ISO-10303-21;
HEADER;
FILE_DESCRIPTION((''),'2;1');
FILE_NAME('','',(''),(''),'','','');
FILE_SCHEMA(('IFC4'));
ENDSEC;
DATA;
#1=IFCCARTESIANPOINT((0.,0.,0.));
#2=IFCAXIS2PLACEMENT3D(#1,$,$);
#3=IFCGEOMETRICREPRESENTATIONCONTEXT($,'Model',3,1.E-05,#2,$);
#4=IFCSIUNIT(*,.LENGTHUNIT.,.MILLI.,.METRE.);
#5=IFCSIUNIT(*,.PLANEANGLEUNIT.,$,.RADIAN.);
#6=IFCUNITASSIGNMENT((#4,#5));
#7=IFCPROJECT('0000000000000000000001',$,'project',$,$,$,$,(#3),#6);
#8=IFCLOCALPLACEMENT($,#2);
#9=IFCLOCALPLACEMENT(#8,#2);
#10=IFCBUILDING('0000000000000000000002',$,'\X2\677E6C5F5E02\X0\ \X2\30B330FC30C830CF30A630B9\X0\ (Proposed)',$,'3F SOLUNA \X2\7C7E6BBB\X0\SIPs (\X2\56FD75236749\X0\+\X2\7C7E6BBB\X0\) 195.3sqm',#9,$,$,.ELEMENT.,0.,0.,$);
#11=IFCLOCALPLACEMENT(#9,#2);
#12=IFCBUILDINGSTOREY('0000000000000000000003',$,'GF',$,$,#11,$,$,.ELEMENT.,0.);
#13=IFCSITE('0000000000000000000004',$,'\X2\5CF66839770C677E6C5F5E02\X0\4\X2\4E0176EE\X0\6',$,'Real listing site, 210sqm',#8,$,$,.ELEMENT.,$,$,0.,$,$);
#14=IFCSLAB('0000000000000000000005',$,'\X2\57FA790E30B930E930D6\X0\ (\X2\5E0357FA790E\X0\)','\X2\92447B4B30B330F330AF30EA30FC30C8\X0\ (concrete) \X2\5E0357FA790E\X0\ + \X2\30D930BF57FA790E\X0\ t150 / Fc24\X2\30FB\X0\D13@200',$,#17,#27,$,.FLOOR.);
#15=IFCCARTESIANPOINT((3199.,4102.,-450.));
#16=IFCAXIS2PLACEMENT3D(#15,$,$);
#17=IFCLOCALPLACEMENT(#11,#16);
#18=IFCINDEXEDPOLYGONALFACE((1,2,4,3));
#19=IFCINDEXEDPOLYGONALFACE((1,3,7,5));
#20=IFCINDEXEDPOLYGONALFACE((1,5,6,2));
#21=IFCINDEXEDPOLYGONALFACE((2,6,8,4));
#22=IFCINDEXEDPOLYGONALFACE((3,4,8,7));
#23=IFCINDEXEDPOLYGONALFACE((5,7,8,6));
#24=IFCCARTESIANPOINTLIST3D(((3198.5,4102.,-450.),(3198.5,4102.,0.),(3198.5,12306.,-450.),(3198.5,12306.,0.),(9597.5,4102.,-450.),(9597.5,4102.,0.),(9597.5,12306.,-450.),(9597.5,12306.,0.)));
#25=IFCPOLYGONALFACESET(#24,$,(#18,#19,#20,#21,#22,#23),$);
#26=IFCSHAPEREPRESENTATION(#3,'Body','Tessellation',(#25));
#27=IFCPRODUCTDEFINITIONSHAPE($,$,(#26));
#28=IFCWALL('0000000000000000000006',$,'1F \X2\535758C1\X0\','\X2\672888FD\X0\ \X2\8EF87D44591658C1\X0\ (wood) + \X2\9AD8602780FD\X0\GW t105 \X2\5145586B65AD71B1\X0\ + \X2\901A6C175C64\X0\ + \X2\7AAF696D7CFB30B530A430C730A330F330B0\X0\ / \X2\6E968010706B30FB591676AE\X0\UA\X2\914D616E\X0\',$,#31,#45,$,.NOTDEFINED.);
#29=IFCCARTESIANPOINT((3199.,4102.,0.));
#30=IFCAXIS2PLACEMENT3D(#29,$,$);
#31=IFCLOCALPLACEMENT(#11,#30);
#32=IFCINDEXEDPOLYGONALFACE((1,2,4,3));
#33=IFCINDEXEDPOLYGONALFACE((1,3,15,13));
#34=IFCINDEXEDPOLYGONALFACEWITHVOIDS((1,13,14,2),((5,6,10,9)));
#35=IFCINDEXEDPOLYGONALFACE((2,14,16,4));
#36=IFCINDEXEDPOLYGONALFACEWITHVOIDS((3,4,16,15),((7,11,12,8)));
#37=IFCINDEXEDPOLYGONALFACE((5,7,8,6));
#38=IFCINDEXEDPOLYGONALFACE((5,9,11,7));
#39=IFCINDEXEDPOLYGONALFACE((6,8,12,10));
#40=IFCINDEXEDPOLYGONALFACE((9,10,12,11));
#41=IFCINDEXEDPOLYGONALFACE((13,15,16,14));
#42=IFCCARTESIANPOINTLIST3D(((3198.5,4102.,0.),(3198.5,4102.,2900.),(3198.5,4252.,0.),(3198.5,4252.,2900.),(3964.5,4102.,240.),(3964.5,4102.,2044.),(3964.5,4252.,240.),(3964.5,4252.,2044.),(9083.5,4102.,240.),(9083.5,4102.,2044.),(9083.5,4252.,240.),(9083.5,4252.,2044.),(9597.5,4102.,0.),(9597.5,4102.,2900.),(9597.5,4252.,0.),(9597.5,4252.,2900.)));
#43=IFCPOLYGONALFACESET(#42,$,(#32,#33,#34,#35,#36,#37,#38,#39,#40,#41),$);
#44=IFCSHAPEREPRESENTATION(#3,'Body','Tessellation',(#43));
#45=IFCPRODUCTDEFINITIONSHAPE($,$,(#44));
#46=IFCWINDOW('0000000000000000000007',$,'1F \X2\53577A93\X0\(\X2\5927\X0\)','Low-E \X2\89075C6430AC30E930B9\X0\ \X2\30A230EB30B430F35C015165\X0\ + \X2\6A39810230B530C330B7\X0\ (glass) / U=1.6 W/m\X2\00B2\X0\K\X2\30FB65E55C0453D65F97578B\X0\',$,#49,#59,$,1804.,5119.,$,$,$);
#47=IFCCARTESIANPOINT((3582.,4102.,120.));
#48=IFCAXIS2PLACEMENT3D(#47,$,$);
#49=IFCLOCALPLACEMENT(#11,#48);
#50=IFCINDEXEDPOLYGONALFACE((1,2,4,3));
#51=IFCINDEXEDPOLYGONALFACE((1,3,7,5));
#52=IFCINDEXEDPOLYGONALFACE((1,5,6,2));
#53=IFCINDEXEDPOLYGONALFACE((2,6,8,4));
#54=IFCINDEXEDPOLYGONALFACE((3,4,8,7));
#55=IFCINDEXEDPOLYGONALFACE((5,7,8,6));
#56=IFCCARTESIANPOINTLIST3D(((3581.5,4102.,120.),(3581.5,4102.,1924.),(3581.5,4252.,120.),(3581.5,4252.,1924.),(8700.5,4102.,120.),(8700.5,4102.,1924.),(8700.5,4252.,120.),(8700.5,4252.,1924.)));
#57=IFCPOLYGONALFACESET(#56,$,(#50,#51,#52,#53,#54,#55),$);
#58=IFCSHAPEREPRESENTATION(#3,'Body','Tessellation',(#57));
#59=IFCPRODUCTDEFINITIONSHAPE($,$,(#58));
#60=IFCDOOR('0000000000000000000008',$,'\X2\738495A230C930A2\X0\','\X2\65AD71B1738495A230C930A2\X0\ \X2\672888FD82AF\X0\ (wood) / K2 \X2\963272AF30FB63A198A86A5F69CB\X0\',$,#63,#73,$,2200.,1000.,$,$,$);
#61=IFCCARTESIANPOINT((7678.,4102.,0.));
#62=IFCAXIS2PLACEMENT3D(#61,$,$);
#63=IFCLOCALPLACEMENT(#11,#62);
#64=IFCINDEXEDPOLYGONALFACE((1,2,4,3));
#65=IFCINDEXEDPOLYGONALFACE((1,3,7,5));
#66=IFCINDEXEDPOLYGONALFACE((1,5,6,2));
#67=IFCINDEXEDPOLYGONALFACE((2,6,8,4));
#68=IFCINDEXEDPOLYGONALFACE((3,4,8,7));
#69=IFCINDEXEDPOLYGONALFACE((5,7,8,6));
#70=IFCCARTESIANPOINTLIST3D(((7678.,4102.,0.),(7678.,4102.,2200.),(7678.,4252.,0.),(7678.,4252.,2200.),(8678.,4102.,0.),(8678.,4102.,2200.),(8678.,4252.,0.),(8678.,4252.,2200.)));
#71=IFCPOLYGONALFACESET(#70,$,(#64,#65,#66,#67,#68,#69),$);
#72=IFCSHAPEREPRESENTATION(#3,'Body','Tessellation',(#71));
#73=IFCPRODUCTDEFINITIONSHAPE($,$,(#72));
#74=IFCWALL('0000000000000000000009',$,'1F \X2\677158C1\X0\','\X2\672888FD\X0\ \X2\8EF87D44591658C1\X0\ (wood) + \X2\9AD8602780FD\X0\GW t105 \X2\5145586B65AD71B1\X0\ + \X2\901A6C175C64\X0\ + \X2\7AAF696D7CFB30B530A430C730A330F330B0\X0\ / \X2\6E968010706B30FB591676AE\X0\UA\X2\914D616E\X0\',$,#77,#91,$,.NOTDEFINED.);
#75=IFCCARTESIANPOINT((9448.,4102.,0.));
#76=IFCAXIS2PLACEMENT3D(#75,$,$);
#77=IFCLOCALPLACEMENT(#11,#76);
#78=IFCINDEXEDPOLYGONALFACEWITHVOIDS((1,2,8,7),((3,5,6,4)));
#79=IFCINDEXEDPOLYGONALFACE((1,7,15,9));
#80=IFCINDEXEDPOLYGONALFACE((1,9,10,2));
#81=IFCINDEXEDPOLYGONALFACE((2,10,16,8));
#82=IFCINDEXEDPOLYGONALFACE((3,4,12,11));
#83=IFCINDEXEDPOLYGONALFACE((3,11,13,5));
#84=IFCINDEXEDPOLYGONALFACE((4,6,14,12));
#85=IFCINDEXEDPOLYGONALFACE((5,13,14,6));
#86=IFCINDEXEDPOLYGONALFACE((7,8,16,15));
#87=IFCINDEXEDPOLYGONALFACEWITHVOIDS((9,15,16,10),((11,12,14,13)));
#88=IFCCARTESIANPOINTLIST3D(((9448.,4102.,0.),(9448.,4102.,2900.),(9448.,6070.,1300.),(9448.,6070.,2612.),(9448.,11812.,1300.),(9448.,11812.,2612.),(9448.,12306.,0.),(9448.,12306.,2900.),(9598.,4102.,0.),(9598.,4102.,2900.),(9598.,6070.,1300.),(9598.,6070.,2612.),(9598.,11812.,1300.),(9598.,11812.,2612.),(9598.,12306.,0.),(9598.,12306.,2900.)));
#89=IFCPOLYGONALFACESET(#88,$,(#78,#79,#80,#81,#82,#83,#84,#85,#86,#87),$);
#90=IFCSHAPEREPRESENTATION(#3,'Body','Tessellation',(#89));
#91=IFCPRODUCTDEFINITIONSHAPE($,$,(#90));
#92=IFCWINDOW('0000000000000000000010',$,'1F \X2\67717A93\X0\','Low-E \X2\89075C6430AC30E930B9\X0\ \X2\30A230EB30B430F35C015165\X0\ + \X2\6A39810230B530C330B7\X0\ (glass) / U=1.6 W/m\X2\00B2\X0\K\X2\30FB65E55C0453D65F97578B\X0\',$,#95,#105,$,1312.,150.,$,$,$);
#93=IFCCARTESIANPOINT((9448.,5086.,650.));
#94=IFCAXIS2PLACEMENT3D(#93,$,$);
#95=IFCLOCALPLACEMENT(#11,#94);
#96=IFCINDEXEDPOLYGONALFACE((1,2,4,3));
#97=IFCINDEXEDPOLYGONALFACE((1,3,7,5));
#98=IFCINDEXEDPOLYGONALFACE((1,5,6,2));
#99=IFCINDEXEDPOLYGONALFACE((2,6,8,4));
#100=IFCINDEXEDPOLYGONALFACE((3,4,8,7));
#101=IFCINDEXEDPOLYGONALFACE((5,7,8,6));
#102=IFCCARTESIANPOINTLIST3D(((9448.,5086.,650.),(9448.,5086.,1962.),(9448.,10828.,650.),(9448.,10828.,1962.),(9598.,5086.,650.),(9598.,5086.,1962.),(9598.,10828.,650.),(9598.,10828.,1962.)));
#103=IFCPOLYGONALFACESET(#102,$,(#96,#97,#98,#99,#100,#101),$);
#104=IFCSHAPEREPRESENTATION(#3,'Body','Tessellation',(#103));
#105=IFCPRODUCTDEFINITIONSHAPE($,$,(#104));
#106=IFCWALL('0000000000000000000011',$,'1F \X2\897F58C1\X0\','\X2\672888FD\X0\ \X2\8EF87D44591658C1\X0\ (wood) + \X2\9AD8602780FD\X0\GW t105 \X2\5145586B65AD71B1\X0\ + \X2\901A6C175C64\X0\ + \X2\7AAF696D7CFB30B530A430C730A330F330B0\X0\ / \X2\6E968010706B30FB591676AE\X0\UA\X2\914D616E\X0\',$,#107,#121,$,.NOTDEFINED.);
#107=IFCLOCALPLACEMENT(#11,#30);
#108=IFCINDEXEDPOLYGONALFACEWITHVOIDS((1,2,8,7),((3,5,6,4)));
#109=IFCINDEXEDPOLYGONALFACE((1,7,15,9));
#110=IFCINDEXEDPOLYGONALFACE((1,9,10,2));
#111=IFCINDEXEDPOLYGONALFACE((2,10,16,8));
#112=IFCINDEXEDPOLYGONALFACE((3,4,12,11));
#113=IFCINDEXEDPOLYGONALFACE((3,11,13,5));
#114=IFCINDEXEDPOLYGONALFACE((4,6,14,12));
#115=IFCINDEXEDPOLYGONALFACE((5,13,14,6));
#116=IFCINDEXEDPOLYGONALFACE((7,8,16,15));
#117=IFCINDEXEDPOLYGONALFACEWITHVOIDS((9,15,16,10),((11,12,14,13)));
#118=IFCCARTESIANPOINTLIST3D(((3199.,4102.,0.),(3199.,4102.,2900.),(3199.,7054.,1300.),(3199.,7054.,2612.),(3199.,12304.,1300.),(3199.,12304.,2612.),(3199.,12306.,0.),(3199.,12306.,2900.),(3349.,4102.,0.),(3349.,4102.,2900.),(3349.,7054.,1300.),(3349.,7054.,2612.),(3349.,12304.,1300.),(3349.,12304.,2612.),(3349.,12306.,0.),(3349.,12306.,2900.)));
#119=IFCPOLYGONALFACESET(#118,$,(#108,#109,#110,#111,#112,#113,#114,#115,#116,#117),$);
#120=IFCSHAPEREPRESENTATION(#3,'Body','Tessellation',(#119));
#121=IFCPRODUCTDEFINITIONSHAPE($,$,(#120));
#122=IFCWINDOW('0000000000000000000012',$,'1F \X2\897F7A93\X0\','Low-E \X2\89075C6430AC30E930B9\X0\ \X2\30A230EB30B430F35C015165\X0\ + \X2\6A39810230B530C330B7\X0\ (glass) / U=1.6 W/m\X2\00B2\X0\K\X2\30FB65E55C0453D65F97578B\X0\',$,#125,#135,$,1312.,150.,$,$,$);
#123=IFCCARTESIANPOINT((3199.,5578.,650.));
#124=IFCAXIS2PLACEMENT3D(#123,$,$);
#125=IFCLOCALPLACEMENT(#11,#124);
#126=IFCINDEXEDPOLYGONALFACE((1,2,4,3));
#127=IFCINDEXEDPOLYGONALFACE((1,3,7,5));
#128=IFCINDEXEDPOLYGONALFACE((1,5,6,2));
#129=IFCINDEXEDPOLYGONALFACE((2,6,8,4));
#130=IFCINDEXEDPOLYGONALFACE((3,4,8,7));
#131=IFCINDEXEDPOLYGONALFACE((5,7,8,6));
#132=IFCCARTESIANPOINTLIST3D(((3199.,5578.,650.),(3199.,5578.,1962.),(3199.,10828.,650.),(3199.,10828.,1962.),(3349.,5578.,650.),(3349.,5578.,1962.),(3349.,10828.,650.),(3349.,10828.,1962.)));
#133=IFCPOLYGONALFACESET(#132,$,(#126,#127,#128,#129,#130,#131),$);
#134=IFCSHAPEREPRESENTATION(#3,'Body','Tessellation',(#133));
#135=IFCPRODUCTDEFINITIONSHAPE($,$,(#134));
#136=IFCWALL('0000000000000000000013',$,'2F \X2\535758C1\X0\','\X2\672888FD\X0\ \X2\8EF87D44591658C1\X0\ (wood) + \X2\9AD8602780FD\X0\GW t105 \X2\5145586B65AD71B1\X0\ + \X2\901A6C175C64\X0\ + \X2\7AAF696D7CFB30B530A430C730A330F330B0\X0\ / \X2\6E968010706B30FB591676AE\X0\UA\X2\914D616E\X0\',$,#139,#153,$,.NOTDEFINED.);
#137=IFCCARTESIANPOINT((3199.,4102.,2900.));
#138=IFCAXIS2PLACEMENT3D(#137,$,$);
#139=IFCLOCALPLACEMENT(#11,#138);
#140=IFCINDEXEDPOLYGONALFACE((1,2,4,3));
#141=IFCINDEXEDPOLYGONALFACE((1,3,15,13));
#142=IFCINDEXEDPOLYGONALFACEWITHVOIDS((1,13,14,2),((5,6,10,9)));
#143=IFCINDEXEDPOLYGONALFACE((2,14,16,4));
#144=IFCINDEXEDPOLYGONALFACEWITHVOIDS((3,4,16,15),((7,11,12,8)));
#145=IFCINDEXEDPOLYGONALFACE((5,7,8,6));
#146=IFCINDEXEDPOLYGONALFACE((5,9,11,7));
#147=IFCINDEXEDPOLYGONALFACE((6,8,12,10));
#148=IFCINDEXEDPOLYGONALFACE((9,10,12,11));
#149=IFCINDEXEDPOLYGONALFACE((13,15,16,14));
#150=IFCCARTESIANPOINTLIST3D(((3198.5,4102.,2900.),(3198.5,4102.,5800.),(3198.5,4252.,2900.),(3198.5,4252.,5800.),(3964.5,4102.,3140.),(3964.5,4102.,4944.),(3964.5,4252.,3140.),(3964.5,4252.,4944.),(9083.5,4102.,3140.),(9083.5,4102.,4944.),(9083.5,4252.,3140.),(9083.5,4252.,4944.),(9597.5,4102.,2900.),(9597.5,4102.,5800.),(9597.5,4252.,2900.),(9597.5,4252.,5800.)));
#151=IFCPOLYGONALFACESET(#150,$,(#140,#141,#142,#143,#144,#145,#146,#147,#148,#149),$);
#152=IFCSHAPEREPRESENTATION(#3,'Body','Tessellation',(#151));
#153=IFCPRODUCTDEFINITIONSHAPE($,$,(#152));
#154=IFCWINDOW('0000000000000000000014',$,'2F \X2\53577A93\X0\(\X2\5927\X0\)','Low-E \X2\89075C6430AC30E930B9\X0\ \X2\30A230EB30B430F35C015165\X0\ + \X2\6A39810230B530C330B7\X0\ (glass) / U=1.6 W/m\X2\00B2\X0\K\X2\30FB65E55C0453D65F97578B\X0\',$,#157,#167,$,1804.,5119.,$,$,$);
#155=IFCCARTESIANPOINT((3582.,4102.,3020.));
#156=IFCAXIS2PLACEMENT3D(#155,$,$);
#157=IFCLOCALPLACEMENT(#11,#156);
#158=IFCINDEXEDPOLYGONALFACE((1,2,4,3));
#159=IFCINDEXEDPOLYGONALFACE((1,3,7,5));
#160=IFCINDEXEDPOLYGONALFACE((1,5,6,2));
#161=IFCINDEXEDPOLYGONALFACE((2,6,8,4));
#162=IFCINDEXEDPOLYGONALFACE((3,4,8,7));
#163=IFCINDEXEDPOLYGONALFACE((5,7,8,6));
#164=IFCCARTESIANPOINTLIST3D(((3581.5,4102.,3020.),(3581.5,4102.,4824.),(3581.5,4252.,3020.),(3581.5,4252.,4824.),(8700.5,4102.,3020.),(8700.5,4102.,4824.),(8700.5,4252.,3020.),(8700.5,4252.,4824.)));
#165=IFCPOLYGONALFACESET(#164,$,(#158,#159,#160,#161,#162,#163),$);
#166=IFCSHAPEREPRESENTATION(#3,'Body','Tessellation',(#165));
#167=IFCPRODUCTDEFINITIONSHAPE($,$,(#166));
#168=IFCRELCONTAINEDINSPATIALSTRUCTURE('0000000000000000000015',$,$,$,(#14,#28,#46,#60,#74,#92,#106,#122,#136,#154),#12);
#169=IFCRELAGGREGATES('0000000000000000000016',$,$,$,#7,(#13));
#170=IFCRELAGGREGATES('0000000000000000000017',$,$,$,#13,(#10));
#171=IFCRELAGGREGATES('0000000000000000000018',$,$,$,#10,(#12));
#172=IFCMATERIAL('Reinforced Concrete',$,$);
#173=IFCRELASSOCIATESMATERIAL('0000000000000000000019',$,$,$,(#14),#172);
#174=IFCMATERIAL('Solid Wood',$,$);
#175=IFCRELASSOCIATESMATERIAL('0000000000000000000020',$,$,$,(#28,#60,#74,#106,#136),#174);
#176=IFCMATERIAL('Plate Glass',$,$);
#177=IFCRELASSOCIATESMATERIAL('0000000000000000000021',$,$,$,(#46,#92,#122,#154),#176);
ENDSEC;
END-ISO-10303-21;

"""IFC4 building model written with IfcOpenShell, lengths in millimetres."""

from ifc_helpers import new_model, si_unit, frame, frame_2d, origin, place, context, project, spatial, rectangle, extrude, material, element, fill, save


model = new_model("IFC4")

# Units and contexts
model_context = context("Model", 3, precision=1e-05, world=origin())
ifc_project = project(units=[si_unit("LENGTHUNIT", "METRE", prefix="MILLI"), si_unit("PLANEANGLEUNIT", "RADIAN")], contexts=[model_context])

# Site, building, storey
site_placement = place(None, origin())
site = spatial("IfcSite", under=ifc_project, at=site_placement, Name="島根県松江市4丁目6", ObjectType="Real listing site, 210sqm", CompositionType="ELEMENT", RefElevation=0.0)
building_placement = place(site_placement, origin())
building = spatial("IfcBuilding", under=site, at=building_placement, Name="松江市 コートハウス (Proposed)", ObjectType="3F SOLUNA 籾殻SIPs (国産杉+籾殻) 195.3sqm", CompositionType="ELEMENT", ElevationOfRefHeight=0.0, ElevationOfTerrain=0.0)
storey_placement = place(building_placement, origin())
storey = spatial("IfcBuildingStorey", under=building, at=storey_placement, Name="GF", CompositionType="ELEMENT", Elevation=0.0)

# Slab
ifc_material_1 = material(Name="Reinforced Concrete")
slab_1_placement = place(storey_placement, frame((3199.0, 4102.0, -450.0)))
element("IfcSlab", 1, at=slab_1_placement, inside=storey, material=ifc_material_1, Name="基礎スラブ (布基礎)", Description="鉄筋コンクリート (concrete) 布基礎 + ベタ基礎 t150 / Fc24・D13@200", PredefinedType="FLOOR", context=model_context, shape_type="SweptSolid", body=[
    extrude(rectangle(XDim=6399.0, YDim=8204.0, at=frame_2d((3199.0, 4102.0))), frame((3199.0, 4102.0, -450.0)), (0.0, 0.0, 1.0), 450.0),
])
ifc_material_2 = material(Name="Solid Wood")

# Wall, openings, window, door
wall_1_placement = place(storey_placement, frame((3199.0, 4102.0, 0.0)))
wall_1 = element("IfcWall", 2, at=wall_1_placement, inside=storey, material=ifc_material_2, Name="1F 南壁", Description="木製 軸組外壁 (wood) + 高性能GW t105 充填断熱 + 通気層 + 窯業系サイディング / 準耐火・外皮UA配慮", PredefinedType="NOTDEFINED", context=model_context, shape_type="SweptSolid", body=[
    extrude(rectangle(XDim=6399.0, YDim=150.0, at=frame_2d((3199.0, 75.0))), frame((3199.0, 4102.0, 0.0)), (0.0, 0.0, 1.0), 2900.0),
])
opening_1_placement = place(storey_placement, frame((3582.0, 4102.0, 120.0)))
opening_1 = element("IfcOpeningElement", 3, at=opening_1_placement, cuts=wall_1, PredefinedType="NOTDEFINED", context=model_context, shape_type="SweptSolid", body=[
    extrude(rectangle(XDim=5119.0, YDim=150.0, at=frame_2d((2559.0, 75.0))), frame((3582.0, 4102.0, 120.0)), (0.0, 0.0, 1.0), 1804.0),
])
opening_2_placement = place(storey_placement, frame((7678.0, 4102.0, 0.0)))
opening_2 = element("IfcOpeningElement", 4, at=opening_2_placement, cuts=wall_1, PredefinedType="NOTDEFINED", context=model_context, shape_type="SweptSolid", body=[
    extrude(rectangle(XDim=1000.0, YDim=150.0, at=frame_2d((500.0, 75.0))), frame((7678.0, 4102.0, 0.0)), (0.0, 0.0, 1.0), 2200.0),
])
ifc_material_3 = material(Name="Plate Glass")
window_1_placement = place(storey_placement, frame((3582.0, 4102.0, 120.0)))
window_1 = element("IfcWindow", 5, at=window_1_placement, inside=storey, material=ifc_material_3, Name="1F 南窓(大)", Description="Low-E 複層ガラス アルゴン封入 + 樹脂サッシ (glass) / U=1.6 W/m²K・日射取得型", OverallHeight=1804.0, OverallWidth=5119.0, context=model_context, shape_type="SweptSolid", body=[
    extrude(rectangle(XDim=5119.0, YDim=150.0, at=frame_2d((2559.0, 75.0))), frame((3582.0, 4102.0, 120.0)), (0.0, 0.0, 1.0), 1804.0),
])
fill(opening_1, window_1)
door_placement = place(storey_placement, frame((7678.0, 4102.0, 0.0)))
door = element("IfcDoor", 6, at=door_placement, inside=storey, material=ifc_material_2, Name="玄関ドア", Description="断熱玄関ドア 木製芯 (wood) / K2 防犯・採風機構", OverallHeight=2200.0, OverallWidth=1000.0, context=model_context, shape_type="SweptSolid", body=[
    extrude(rectangle(XDim=1000.0, YDim=150.0, at=frame_2d((500.0, 75.0))), frame((7678.0, 4102.0, 0.0)), (0.0, 0.0, 1.0), 2200.0),
])
fill(opening_2, door)

# Walls, openings, windows
wall_2_placement = place(storey_placement, frame((9448.0, 4102.0, 0.0)))
wall_2 = element("IfcWall", 7, at=wall_2_placement, inside=storey, material=ifc_material_2, Name="1F 東壁", Description="木製 軸組外壁 (wood) + 高性能GW t105 充填断熱 + 通気層 + 窯業系サイディング / 準耐火・外皮UA配慮", PredefinedType="NOTDEFINED", context=model_context, shape_type="SweptSolid", body=[
    extrude(rectangle(XDim=150.0, YDim=8204.0, at=frame_2d((75.0, 4102.0))), frame((9448.0, 4102.0, 0.0)), (0.0, 0.0, 1.0), 2900.0),
])
opening_3_placement = place(storey_placement, frame((9448.0, 5086.0, 650.0)))
opening_3 = element("IfcOpeningElement", 8, at=opening_3_placement, cuts=wall_2, PredefinedType="NOTDEFINED", context=model_context, shape_type="SweptSolid", body=[
    extrude(rectangle(XDim=150.0, YDim=5742.0, at=frame_2d((75.0, 2871.0))), frame((9448.0, 5086.0, 650.0)), (0.0, 0.0, 1.0), 1312.0),
])
window_2_placement = place(storey_placement, frame((9448.0, 5086.0, 650.0)))
window_2 = element("IfcWindow", 9, at=window_2_placement, inside=storey, material=ifc_material_3, Name="1F 東窓", Description="Low-E 複層ガラス アルゴン封入 + 樹脂サッシ (glass) / U=1.6 W/m²K・日射取得型", OverallHeight=1312.0, OverallWidth=150.0, context=model_context, shape_type="SweptSolid", body=[
    extrude(rectangle(XDim=150.0, YDim=5742.0, at=frame_2d((75.0, 2871.0))), frame((9448.0, 5086.0, 650.0)), (0.0, 0.0, 1.0), 1312.0),
])
fill(opening_3, window_2)
wall_3_placement = place(storey_placement, frame((3199.0, 4102.0, 0.0)))
wall_3 = element("IfcWall", 10, at=wall_3_placement, inside=storey, material=ifc_material_2, Name="1F 西壁", Description="木製 軸組外壁 (wood) + 高性能GW t105 充填断熱 + 通気層 + 窯業系サイディング / 準耐火・外皮UA配慮", PredefinedType="NOTDEFINED", context=model_context, shape_type="SweptSolid", body=[
    extrude(rectangle(XDim=150.0, YDim=8204.0, at=frame_2d((75.0, 4102.0))), frame((3199.0, 4102.0, 0.0)), (0.0, 0.0, 1.0), 2900.0),
])
opening_4_placement = place(storey_placement, frame((3199.0, 5578.0, 650.0)))
opening_4 = element("IfcOpeningElement", 11, at=opening_4_placement, cuts=wall_3, PredefinedType="NOTDEFINED", context=model_context, shape_type="SweptSolid", body=[
    extrude(rectangle(XDim=150.0, YDim=5250.0, at=frame_2d((75.0, 2625.0))), frame((3199.0, 5578.0, 650.0)), (0.0, 0.0, 1.0), 1312.0),
])
window_3_placement = place(storey_placement, frame((3199.0, 5578.0, 650.0)))
window_3 = element("IfcWindow", 12, at=window_3_placement, inside=storey, material=ifc_material_3, Name="1F 西窓", Description="Low-E 複層ガラス アルゴン封入 + 樹脂サッシ (glass) / U=1.6 W/m²K・日射取得型", OverallHeight=1312.0, OverallWidth=150.0, context=model_context, shape_type="SweptSolid", body=[
    extrude(rectangle(XDim=150.0, YDim=5250.0, at=frame_2d((75.0, 2625.0))), frame((3199.0, 5578.0, 650.0)), (0.0, 0.0, 1.0), 1312.0),
])
fill(opening_4, window_3)
wall_4_placement = place(storey_placement, frame((3199.0, 4102.0, 2900.0)))
wall_4 = element("IfcWall", 13, at=wall_4_placement, inside=storey, material=ifc_material_2, Name="2F 南壁", Description="木製 軸組外壁 (wood) + 高性能GW t105 充填断熱 + 通気層 + 窯業系サイディング / 準耐火・外皮UA配慮", PredefinedType="NOTDEFINED", context=model_context, shape_type="SweptSolid", body=[
    extrude(rectangle(XDim=6399.0, YDim=150.0, at=frame_2d((3199.0, 75.0))), frame((3199.0, 4102.0, 2900.0)), (0.0, 0.0, 1.0), 2900.0),
])
opening_5_placement = place(storey_placement, frame((3582.0, 4102.0, 3020.0)))
opening_5 = element("IfcOpeningElement", 14, at=opening_5_placement, cuts=wall_4, PredefinedType="NOTDEFINED", context=model_context, shape_type="SweptSolid", body=[
    extrude(rectangle(XDim=5119.0, YDim=150.0, at=frame_2d((2559.0, 75.0))), frame((3582.0, 4102.0, 3020.0)), (0.0, 0.0, 1.0), 1804.0),
])
window_4_placement = place(storey_placement, frame((3582.0, 4102.0, 3020.0)))
window_4 = element("IfcWindow", 15, at=window_4_placement, inside=storey, material=ifc_material_3, Name="2F 南窓(大)", Description="Low-E 複層ガラス アルゴン封入 + 樹脂サッシ (glass) / U=1.6 W/m²K・日射取得型", OverallHeight=1804.0, OverallWidth=5119.0, context=model_context, shape_type="SweptSolid", body=[
    extrude(rectangle(XDim=5119.0, YDim=150.0, at=frame_2d((2559.0, 75.0))), frame((3582.0, 4102.0, 3020.0)), (0.0, 0.0, 1.0), 1804.0),
])
fill(opening_5, window_4)

save(model, "model.ifc")
